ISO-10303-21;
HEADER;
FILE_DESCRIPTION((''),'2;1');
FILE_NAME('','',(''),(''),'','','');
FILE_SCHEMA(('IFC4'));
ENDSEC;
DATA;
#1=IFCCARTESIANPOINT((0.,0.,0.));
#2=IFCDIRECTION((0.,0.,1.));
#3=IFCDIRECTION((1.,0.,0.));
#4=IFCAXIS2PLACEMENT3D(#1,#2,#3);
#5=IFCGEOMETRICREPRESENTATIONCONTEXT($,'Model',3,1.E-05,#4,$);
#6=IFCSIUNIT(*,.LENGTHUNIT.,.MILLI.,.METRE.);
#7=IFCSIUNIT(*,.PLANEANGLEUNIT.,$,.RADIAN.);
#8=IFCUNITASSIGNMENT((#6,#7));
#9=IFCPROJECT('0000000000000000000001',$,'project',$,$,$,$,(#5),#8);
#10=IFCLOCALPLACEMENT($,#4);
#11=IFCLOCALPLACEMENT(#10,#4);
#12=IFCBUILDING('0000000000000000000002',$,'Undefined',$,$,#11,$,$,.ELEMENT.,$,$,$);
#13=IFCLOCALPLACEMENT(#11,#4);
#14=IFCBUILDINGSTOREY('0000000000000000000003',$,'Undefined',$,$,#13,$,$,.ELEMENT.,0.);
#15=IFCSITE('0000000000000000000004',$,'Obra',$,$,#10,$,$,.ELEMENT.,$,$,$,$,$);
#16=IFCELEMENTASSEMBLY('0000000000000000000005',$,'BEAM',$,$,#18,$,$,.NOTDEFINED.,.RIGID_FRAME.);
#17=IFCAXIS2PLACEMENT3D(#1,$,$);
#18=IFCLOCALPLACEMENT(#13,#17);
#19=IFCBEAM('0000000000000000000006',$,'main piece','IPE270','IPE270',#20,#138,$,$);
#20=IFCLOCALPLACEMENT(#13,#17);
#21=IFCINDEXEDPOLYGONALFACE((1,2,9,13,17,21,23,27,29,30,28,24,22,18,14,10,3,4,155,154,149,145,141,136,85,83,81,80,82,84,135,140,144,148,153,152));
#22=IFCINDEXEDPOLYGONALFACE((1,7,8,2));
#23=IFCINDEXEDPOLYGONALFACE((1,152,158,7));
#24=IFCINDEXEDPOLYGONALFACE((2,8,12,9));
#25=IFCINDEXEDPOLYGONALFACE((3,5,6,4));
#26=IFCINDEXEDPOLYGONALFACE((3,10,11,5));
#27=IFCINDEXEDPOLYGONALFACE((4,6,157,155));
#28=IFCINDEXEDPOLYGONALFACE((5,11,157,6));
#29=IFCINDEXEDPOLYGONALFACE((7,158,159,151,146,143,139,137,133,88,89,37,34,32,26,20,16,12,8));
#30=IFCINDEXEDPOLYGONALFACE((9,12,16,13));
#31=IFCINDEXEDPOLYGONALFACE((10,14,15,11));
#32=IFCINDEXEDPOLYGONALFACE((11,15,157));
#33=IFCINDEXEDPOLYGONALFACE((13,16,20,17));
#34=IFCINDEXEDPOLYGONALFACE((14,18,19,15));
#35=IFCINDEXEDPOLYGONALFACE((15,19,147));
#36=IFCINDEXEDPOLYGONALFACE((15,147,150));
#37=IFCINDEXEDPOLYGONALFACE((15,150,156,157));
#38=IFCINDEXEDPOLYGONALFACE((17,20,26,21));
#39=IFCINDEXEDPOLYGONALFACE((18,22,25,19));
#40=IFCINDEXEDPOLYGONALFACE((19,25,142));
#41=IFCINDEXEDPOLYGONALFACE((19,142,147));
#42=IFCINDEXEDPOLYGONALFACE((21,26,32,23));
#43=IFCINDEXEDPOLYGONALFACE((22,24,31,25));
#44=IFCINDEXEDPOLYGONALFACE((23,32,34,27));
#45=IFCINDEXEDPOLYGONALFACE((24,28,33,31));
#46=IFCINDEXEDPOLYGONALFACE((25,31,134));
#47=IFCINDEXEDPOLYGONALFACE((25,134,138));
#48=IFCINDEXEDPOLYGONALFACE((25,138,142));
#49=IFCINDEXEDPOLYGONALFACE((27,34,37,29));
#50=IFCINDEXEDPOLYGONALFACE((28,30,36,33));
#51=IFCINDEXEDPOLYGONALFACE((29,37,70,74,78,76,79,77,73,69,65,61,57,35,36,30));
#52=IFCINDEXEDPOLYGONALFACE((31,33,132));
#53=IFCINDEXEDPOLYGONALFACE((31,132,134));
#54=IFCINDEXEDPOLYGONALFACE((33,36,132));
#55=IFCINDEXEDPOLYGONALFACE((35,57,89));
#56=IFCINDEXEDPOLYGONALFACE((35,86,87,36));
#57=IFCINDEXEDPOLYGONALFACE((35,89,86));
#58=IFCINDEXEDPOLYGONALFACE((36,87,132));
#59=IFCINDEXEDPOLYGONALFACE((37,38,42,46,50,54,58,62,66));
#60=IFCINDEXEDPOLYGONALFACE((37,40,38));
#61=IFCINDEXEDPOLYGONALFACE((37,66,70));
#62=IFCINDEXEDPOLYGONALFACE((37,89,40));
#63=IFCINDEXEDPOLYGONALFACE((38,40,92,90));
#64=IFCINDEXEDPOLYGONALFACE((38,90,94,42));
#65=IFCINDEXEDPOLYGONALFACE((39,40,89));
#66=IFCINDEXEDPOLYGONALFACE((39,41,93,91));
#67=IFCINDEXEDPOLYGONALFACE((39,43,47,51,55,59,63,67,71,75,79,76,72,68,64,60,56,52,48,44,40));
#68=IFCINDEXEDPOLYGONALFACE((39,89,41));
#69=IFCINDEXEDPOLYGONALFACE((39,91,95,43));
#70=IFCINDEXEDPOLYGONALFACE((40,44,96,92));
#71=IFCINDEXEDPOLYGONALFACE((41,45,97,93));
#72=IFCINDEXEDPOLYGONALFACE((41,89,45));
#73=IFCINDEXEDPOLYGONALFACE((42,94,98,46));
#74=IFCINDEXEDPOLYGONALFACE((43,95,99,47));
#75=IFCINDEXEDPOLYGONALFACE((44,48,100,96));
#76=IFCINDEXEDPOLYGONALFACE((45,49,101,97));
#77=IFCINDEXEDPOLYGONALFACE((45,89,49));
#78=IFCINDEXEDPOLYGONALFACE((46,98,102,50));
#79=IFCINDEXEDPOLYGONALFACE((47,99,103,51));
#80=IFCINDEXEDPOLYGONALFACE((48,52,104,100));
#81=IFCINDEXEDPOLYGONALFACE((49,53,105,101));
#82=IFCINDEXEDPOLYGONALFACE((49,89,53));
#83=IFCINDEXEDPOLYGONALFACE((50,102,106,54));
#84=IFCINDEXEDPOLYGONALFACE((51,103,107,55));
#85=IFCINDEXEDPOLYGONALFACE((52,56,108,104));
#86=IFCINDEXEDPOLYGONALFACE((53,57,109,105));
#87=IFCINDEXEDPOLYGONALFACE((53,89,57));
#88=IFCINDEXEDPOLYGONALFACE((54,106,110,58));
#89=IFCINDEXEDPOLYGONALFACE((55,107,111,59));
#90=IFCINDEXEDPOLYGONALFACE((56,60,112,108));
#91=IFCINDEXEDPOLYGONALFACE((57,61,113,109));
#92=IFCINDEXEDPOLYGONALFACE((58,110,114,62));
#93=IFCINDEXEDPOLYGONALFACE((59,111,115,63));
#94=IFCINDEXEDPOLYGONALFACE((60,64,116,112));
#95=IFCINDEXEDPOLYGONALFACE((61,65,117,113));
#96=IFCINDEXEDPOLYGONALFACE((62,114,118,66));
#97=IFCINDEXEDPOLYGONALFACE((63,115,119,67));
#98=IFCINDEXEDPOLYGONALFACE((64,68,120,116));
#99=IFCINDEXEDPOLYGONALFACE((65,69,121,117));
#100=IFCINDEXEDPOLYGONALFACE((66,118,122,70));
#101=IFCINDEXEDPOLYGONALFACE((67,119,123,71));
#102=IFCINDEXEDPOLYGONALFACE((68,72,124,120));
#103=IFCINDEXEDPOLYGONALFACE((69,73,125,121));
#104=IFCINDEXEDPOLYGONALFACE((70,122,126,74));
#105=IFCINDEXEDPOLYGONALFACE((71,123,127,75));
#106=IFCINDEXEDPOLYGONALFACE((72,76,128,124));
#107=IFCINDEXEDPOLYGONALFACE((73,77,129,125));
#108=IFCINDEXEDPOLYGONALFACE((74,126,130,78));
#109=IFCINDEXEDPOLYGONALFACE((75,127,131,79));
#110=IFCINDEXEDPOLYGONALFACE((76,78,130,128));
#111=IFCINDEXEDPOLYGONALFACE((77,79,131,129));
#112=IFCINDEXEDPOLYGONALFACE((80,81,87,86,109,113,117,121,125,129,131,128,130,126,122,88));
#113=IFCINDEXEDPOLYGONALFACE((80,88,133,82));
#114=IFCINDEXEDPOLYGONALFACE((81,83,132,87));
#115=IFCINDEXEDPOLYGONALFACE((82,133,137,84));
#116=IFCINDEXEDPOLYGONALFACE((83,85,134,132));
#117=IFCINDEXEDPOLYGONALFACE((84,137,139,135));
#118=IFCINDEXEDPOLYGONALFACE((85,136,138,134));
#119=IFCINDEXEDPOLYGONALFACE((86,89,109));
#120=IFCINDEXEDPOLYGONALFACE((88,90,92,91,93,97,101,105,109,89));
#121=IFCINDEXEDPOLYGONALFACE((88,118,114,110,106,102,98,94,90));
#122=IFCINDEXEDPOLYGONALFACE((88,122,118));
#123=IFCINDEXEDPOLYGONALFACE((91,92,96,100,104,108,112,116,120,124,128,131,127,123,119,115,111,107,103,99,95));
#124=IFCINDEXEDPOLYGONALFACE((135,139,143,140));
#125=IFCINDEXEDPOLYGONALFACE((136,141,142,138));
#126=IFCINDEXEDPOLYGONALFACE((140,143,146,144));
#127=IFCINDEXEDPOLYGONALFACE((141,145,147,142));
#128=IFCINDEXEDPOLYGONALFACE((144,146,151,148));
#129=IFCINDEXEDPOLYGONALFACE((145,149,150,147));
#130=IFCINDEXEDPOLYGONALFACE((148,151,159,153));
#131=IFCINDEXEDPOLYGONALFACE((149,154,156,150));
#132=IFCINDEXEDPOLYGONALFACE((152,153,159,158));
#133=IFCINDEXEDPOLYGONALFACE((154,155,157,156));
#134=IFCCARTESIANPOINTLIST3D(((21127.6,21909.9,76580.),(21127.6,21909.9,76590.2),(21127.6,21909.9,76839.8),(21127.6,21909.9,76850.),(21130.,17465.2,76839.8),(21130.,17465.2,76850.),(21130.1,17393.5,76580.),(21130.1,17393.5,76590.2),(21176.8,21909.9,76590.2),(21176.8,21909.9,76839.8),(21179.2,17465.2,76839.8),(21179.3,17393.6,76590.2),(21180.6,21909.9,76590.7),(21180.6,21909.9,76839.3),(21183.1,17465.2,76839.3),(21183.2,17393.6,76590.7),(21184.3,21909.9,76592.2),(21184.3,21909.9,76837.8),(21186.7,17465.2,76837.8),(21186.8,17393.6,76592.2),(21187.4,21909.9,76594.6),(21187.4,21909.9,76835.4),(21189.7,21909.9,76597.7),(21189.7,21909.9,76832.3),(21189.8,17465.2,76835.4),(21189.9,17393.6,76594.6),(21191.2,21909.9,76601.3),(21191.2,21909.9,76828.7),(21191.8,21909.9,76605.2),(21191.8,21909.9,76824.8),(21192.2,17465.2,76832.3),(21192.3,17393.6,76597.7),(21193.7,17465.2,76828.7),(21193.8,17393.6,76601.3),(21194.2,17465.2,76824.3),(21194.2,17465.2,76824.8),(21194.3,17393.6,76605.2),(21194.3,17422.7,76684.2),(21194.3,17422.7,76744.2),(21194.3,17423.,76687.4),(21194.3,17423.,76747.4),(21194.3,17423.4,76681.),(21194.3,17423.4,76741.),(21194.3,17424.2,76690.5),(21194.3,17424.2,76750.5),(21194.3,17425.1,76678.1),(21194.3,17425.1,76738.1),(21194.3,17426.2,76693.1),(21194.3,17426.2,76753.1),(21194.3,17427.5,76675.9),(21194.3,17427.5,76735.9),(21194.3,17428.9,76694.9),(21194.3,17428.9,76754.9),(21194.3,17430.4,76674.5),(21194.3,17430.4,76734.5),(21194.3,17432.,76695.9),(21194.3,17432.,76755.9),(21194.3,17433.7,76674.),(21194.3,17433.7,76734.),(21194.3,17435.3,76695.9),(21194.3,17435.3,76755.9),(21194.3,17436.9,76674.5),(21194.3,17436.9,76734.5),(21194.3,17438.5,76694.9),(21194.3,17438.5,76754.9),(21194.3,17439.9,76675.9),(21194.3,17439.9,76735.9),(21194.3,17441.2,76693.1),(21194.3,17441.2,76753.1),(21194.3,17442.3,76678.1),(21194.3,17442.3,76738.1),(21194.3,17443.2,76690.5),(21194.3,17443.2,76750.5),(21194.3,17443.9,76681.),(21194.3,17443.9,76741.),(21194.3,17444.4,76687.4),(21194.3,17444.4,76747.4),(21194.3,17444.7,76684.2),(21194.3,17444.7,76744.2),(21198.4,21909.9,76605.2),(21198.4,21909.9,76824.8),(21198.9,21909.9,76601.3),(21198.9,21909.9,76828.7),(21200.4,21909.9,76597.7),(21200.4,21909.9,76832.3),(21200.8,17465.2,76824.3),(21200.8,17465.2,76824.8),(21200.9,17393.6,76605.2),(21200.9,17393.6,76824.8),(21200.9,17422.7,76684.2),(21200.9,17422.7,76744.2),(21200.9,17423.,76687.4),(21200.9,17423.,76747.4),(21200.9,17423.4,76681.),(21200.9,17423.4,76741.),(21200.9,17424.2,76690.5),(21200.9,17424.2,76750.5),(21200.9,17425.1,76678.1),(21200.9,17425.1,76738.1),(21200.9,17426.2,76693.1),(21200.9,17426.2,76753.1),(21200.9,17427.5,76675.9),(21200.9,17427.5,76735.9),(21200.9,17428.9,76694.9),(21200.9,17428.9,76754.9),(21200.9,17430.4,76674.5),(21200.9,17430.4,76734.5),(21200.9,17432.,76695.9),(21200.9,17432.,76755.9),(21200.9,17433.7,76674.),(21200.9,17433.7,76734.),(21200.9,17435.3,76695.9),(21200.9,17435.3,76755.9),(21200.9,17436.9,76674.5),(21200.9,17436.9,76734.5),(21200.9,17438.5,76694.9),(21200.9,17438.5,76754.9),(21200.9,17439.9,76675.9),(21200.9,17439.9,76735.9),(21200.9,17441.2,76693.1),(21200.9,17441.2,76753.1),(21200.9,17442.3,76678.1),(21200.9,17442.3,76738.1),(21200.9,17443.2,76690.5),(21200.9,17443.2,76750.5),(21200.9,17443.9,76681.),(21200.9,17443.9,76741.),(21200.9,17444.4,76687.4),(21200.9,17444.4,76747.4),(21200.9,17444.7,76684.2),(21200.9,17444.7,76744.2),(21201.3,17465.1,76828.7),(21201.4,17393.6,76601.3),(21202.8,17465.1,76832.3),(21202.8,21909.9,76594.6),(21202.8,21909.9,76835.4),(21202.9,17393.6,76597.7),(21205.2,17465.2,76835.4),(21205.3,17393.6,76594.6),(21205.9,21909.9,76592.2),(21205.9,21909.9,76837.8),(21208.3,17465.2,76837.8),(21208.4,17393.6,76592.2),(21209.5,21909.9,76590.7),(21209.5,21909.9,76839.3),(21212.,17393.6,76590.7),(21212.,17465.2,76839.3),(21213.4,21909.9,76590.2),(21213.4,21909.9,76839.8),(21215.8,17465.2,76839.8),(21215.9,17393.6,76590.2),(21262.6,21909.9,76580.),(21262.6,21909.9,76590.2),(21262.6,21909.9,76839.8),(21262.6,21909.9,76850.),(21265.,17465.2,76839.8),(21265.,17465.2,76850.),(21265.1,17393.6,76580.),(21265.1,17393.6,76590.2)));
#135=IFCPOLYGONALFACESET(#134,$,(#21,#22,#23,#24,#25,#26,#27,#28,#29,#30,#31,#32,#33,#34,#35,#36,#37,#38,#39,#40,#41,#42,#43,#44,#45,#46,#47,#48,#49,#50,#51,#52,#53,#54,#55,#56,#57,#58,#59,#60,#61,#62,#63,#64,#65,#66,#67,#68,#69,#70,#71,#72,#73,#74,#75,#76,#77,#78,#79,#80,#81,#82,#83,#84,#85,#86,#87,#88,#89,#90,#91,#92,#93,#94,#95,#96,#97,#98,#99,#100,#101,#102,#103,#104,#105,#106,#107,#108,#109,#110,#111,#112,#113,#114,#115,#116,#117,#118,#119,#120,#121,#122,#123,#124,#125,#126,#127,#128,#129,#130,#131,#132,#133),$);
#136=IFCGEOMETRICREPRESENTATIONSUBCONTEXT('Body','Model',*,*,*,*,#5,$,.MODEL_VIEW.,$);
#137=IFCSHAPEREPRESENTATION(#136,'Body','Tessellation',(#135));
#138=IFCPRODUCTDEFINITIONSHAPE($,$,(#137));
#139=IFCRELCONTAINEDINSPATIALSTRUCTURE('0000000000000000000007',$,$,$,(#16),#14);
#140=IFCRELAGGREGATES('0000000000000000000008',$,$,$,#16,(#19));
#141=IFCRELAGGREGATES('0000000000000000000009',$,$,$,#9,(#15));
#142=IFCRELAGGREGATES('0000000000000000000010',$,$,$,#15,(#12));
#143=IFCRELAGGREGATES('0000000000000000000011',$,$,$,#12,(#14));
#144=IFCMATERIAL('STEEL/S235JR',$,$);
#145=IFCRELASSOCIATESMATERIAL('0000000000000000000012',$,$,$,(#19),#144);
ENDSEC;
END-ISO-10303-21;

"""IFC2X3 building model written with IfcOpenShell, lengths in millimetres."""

from ifc_helpers import new_model, si_unit, frame, origin_with_axes, origin_2d_with_axis, place, context, subcontext, project, spatial, rectangle, circle, i_section, extrude, clip, halfspace, source, transform, mapped, material, element, aggregate, save


model = new_model("IFC2X3")

# Units and contexts
model_context = context("Model", 3, precision=1e-05, world=origin_with_axes())
body_context = subcontext(model_context, "Body", "Model", "MODEL_VIEW")
ifc_project = project(units=[si_unit("LENGTHUNIT", "METRE", prefix="MILLI"), si_unit("PLANEANGLEUNIT", "RADIAN")], contexts=[model_context])

# Site, building, storey
site_placement = place(None, origin_with_axes())
site = spatial("IfcSite", under=ifc_project, at=site_placement, Name="Obra", CompositionType="ELEMENT")
building_placement = place(site_placement, origin_with_axes())
building = spatial("IfcBuilding", under=site, at=building_placement, Name="Undefined", CompositionType="ELEMENT")
storey_placement = place(building_placement, origin_with_axes())
storey = spatial("IfcBuildingStorey", under=building, at=storey_placement, Name="Undefined", CompositionType="ELEMENT", Elevation=0.0)

# Shared definitions
ifc_material = material(Name="STEEL/S235JR")

# Element assembly, beam, openings
assembly_1_placement = place(storey_placement, origin_with_axes())
assembly_1 = element("IfcElementAssembly", 1, at=assembly_1_placement, inside=storey, Name="BEAM", AssemblyPlace="NOTDEFINED", PredefinedType="RIGID_FRAME")
beam_1_placement = place(assembly_1_placement, frame((21197.5, 17475.1, 76715.0), z_axis=(0.0, 0.0, 1.0), x_axis=(-0.000557, 1.0, 0.0)))
beam_1 = element("IfcBeam", 2, at=beam_1_placement, material=ifc_material, Name="main piece", Description="IPE270", ObjectType="IPE270", context=body_context, shape_type="Clipping", body=[
    clip(extrude(i_section(OverallWidth=135.0, OverallDepth=270.0, WebThickness=6.6, FlangeThickness=10.2, FilletRadius=15.0, at=origin_2d_with_axis()), frame((4434.8, 0.0, 0.0), z_axis=(-1.0, 0.0, 0.0), x_axis=(0.0, -1.0, 0.0)), (0.0, 0.0, 1.0), 4516.3), halfspace(frame((-81.4, 0.0, -235.0), z_axis=(1.0, -0.000557, 0.0), x_axis=(-0.000557, -1.0, 0.0)), True)),
])
opening_1_placement = place(assembly_1_placement, frame((21197.5, 17475.1, 76715.0), z_axis=(0.0, 0.0, 1.0), x_axis=(-0.000557, 1.0, 0.0)))
element("IfcOpeningElement", 3, at=opening_1_placement, cuts=beam_1, ObjectType="Recess", context=body_context, shape_type="SweptSolid", body=[
    extrude(rectangle(XDim=75.0, YDim=300.0, at=origin_2d_with_axis()), frame((-54.0, -153.3, 124.3), z_axis=(0.0, 0.0, -1.0), x_axis=(1.0, -0.000557, 0.0)), (0.0, 0.0, 1.0), 278.6),
])
opening_2_placement = place(assembly_1_placement, frame((21197.5, 17475.1, 76715.0), z_axis=(0.0, 0.0, 1.0), x_axis=(-0.000557, 1.0, 0.0)))
element("IfcOpeningElement", 4, at=opening_2_placement, cuts=beam_1, ObjectType="Recess", context=body_context, shape_type="SweptSolid", body=[
    extrude(rectangle(XDim=26.7, YDim=83.5, at=origin_2d_with_axis()), frame((-51.7, -68.5, 122.7), z_axis=(0.000557, 1.0, 0.0), x_axis=(0.0, 0.0, -1.0)), (0.0, 0.0, 1.0), 139.5),
])
shared_shape_1 = source(origin_with_axes(), body_context, "Body", "SweptSolid", [
    extrude(circle(Radius=11.0, at=origin_2d_with_axis()), frame((0.0, -3.4, 0.0), z_axis=(0.0, 1.0, 0.0), x_axis=(1.0, 0.0, 0.0)), (0.0, 0.0, 1.0), 6.8),
])
opening_3_placement = place(assembly_1_placement, frame((21197.6, 17393.7, 76850.0), z_axis=(0.0, 1.0, 0.0), x_axis=(0.0, 0.0, -1.0)))
element("IfcOpeningElement", 5, at=opening_3_placement, cuts=beam_1, ObjectType="Opening", context=body_context, shape_type="MappedRepresentation", body=[
    mapped(shared_shape_1, transform((105.0, 0.0, 40.0))),
    mapped(shared_shape_1, transform((165.0, 0.0, 40.0))),
])
aggregate(assembly_1, [beam_1])

save(model, "model.ifc")
